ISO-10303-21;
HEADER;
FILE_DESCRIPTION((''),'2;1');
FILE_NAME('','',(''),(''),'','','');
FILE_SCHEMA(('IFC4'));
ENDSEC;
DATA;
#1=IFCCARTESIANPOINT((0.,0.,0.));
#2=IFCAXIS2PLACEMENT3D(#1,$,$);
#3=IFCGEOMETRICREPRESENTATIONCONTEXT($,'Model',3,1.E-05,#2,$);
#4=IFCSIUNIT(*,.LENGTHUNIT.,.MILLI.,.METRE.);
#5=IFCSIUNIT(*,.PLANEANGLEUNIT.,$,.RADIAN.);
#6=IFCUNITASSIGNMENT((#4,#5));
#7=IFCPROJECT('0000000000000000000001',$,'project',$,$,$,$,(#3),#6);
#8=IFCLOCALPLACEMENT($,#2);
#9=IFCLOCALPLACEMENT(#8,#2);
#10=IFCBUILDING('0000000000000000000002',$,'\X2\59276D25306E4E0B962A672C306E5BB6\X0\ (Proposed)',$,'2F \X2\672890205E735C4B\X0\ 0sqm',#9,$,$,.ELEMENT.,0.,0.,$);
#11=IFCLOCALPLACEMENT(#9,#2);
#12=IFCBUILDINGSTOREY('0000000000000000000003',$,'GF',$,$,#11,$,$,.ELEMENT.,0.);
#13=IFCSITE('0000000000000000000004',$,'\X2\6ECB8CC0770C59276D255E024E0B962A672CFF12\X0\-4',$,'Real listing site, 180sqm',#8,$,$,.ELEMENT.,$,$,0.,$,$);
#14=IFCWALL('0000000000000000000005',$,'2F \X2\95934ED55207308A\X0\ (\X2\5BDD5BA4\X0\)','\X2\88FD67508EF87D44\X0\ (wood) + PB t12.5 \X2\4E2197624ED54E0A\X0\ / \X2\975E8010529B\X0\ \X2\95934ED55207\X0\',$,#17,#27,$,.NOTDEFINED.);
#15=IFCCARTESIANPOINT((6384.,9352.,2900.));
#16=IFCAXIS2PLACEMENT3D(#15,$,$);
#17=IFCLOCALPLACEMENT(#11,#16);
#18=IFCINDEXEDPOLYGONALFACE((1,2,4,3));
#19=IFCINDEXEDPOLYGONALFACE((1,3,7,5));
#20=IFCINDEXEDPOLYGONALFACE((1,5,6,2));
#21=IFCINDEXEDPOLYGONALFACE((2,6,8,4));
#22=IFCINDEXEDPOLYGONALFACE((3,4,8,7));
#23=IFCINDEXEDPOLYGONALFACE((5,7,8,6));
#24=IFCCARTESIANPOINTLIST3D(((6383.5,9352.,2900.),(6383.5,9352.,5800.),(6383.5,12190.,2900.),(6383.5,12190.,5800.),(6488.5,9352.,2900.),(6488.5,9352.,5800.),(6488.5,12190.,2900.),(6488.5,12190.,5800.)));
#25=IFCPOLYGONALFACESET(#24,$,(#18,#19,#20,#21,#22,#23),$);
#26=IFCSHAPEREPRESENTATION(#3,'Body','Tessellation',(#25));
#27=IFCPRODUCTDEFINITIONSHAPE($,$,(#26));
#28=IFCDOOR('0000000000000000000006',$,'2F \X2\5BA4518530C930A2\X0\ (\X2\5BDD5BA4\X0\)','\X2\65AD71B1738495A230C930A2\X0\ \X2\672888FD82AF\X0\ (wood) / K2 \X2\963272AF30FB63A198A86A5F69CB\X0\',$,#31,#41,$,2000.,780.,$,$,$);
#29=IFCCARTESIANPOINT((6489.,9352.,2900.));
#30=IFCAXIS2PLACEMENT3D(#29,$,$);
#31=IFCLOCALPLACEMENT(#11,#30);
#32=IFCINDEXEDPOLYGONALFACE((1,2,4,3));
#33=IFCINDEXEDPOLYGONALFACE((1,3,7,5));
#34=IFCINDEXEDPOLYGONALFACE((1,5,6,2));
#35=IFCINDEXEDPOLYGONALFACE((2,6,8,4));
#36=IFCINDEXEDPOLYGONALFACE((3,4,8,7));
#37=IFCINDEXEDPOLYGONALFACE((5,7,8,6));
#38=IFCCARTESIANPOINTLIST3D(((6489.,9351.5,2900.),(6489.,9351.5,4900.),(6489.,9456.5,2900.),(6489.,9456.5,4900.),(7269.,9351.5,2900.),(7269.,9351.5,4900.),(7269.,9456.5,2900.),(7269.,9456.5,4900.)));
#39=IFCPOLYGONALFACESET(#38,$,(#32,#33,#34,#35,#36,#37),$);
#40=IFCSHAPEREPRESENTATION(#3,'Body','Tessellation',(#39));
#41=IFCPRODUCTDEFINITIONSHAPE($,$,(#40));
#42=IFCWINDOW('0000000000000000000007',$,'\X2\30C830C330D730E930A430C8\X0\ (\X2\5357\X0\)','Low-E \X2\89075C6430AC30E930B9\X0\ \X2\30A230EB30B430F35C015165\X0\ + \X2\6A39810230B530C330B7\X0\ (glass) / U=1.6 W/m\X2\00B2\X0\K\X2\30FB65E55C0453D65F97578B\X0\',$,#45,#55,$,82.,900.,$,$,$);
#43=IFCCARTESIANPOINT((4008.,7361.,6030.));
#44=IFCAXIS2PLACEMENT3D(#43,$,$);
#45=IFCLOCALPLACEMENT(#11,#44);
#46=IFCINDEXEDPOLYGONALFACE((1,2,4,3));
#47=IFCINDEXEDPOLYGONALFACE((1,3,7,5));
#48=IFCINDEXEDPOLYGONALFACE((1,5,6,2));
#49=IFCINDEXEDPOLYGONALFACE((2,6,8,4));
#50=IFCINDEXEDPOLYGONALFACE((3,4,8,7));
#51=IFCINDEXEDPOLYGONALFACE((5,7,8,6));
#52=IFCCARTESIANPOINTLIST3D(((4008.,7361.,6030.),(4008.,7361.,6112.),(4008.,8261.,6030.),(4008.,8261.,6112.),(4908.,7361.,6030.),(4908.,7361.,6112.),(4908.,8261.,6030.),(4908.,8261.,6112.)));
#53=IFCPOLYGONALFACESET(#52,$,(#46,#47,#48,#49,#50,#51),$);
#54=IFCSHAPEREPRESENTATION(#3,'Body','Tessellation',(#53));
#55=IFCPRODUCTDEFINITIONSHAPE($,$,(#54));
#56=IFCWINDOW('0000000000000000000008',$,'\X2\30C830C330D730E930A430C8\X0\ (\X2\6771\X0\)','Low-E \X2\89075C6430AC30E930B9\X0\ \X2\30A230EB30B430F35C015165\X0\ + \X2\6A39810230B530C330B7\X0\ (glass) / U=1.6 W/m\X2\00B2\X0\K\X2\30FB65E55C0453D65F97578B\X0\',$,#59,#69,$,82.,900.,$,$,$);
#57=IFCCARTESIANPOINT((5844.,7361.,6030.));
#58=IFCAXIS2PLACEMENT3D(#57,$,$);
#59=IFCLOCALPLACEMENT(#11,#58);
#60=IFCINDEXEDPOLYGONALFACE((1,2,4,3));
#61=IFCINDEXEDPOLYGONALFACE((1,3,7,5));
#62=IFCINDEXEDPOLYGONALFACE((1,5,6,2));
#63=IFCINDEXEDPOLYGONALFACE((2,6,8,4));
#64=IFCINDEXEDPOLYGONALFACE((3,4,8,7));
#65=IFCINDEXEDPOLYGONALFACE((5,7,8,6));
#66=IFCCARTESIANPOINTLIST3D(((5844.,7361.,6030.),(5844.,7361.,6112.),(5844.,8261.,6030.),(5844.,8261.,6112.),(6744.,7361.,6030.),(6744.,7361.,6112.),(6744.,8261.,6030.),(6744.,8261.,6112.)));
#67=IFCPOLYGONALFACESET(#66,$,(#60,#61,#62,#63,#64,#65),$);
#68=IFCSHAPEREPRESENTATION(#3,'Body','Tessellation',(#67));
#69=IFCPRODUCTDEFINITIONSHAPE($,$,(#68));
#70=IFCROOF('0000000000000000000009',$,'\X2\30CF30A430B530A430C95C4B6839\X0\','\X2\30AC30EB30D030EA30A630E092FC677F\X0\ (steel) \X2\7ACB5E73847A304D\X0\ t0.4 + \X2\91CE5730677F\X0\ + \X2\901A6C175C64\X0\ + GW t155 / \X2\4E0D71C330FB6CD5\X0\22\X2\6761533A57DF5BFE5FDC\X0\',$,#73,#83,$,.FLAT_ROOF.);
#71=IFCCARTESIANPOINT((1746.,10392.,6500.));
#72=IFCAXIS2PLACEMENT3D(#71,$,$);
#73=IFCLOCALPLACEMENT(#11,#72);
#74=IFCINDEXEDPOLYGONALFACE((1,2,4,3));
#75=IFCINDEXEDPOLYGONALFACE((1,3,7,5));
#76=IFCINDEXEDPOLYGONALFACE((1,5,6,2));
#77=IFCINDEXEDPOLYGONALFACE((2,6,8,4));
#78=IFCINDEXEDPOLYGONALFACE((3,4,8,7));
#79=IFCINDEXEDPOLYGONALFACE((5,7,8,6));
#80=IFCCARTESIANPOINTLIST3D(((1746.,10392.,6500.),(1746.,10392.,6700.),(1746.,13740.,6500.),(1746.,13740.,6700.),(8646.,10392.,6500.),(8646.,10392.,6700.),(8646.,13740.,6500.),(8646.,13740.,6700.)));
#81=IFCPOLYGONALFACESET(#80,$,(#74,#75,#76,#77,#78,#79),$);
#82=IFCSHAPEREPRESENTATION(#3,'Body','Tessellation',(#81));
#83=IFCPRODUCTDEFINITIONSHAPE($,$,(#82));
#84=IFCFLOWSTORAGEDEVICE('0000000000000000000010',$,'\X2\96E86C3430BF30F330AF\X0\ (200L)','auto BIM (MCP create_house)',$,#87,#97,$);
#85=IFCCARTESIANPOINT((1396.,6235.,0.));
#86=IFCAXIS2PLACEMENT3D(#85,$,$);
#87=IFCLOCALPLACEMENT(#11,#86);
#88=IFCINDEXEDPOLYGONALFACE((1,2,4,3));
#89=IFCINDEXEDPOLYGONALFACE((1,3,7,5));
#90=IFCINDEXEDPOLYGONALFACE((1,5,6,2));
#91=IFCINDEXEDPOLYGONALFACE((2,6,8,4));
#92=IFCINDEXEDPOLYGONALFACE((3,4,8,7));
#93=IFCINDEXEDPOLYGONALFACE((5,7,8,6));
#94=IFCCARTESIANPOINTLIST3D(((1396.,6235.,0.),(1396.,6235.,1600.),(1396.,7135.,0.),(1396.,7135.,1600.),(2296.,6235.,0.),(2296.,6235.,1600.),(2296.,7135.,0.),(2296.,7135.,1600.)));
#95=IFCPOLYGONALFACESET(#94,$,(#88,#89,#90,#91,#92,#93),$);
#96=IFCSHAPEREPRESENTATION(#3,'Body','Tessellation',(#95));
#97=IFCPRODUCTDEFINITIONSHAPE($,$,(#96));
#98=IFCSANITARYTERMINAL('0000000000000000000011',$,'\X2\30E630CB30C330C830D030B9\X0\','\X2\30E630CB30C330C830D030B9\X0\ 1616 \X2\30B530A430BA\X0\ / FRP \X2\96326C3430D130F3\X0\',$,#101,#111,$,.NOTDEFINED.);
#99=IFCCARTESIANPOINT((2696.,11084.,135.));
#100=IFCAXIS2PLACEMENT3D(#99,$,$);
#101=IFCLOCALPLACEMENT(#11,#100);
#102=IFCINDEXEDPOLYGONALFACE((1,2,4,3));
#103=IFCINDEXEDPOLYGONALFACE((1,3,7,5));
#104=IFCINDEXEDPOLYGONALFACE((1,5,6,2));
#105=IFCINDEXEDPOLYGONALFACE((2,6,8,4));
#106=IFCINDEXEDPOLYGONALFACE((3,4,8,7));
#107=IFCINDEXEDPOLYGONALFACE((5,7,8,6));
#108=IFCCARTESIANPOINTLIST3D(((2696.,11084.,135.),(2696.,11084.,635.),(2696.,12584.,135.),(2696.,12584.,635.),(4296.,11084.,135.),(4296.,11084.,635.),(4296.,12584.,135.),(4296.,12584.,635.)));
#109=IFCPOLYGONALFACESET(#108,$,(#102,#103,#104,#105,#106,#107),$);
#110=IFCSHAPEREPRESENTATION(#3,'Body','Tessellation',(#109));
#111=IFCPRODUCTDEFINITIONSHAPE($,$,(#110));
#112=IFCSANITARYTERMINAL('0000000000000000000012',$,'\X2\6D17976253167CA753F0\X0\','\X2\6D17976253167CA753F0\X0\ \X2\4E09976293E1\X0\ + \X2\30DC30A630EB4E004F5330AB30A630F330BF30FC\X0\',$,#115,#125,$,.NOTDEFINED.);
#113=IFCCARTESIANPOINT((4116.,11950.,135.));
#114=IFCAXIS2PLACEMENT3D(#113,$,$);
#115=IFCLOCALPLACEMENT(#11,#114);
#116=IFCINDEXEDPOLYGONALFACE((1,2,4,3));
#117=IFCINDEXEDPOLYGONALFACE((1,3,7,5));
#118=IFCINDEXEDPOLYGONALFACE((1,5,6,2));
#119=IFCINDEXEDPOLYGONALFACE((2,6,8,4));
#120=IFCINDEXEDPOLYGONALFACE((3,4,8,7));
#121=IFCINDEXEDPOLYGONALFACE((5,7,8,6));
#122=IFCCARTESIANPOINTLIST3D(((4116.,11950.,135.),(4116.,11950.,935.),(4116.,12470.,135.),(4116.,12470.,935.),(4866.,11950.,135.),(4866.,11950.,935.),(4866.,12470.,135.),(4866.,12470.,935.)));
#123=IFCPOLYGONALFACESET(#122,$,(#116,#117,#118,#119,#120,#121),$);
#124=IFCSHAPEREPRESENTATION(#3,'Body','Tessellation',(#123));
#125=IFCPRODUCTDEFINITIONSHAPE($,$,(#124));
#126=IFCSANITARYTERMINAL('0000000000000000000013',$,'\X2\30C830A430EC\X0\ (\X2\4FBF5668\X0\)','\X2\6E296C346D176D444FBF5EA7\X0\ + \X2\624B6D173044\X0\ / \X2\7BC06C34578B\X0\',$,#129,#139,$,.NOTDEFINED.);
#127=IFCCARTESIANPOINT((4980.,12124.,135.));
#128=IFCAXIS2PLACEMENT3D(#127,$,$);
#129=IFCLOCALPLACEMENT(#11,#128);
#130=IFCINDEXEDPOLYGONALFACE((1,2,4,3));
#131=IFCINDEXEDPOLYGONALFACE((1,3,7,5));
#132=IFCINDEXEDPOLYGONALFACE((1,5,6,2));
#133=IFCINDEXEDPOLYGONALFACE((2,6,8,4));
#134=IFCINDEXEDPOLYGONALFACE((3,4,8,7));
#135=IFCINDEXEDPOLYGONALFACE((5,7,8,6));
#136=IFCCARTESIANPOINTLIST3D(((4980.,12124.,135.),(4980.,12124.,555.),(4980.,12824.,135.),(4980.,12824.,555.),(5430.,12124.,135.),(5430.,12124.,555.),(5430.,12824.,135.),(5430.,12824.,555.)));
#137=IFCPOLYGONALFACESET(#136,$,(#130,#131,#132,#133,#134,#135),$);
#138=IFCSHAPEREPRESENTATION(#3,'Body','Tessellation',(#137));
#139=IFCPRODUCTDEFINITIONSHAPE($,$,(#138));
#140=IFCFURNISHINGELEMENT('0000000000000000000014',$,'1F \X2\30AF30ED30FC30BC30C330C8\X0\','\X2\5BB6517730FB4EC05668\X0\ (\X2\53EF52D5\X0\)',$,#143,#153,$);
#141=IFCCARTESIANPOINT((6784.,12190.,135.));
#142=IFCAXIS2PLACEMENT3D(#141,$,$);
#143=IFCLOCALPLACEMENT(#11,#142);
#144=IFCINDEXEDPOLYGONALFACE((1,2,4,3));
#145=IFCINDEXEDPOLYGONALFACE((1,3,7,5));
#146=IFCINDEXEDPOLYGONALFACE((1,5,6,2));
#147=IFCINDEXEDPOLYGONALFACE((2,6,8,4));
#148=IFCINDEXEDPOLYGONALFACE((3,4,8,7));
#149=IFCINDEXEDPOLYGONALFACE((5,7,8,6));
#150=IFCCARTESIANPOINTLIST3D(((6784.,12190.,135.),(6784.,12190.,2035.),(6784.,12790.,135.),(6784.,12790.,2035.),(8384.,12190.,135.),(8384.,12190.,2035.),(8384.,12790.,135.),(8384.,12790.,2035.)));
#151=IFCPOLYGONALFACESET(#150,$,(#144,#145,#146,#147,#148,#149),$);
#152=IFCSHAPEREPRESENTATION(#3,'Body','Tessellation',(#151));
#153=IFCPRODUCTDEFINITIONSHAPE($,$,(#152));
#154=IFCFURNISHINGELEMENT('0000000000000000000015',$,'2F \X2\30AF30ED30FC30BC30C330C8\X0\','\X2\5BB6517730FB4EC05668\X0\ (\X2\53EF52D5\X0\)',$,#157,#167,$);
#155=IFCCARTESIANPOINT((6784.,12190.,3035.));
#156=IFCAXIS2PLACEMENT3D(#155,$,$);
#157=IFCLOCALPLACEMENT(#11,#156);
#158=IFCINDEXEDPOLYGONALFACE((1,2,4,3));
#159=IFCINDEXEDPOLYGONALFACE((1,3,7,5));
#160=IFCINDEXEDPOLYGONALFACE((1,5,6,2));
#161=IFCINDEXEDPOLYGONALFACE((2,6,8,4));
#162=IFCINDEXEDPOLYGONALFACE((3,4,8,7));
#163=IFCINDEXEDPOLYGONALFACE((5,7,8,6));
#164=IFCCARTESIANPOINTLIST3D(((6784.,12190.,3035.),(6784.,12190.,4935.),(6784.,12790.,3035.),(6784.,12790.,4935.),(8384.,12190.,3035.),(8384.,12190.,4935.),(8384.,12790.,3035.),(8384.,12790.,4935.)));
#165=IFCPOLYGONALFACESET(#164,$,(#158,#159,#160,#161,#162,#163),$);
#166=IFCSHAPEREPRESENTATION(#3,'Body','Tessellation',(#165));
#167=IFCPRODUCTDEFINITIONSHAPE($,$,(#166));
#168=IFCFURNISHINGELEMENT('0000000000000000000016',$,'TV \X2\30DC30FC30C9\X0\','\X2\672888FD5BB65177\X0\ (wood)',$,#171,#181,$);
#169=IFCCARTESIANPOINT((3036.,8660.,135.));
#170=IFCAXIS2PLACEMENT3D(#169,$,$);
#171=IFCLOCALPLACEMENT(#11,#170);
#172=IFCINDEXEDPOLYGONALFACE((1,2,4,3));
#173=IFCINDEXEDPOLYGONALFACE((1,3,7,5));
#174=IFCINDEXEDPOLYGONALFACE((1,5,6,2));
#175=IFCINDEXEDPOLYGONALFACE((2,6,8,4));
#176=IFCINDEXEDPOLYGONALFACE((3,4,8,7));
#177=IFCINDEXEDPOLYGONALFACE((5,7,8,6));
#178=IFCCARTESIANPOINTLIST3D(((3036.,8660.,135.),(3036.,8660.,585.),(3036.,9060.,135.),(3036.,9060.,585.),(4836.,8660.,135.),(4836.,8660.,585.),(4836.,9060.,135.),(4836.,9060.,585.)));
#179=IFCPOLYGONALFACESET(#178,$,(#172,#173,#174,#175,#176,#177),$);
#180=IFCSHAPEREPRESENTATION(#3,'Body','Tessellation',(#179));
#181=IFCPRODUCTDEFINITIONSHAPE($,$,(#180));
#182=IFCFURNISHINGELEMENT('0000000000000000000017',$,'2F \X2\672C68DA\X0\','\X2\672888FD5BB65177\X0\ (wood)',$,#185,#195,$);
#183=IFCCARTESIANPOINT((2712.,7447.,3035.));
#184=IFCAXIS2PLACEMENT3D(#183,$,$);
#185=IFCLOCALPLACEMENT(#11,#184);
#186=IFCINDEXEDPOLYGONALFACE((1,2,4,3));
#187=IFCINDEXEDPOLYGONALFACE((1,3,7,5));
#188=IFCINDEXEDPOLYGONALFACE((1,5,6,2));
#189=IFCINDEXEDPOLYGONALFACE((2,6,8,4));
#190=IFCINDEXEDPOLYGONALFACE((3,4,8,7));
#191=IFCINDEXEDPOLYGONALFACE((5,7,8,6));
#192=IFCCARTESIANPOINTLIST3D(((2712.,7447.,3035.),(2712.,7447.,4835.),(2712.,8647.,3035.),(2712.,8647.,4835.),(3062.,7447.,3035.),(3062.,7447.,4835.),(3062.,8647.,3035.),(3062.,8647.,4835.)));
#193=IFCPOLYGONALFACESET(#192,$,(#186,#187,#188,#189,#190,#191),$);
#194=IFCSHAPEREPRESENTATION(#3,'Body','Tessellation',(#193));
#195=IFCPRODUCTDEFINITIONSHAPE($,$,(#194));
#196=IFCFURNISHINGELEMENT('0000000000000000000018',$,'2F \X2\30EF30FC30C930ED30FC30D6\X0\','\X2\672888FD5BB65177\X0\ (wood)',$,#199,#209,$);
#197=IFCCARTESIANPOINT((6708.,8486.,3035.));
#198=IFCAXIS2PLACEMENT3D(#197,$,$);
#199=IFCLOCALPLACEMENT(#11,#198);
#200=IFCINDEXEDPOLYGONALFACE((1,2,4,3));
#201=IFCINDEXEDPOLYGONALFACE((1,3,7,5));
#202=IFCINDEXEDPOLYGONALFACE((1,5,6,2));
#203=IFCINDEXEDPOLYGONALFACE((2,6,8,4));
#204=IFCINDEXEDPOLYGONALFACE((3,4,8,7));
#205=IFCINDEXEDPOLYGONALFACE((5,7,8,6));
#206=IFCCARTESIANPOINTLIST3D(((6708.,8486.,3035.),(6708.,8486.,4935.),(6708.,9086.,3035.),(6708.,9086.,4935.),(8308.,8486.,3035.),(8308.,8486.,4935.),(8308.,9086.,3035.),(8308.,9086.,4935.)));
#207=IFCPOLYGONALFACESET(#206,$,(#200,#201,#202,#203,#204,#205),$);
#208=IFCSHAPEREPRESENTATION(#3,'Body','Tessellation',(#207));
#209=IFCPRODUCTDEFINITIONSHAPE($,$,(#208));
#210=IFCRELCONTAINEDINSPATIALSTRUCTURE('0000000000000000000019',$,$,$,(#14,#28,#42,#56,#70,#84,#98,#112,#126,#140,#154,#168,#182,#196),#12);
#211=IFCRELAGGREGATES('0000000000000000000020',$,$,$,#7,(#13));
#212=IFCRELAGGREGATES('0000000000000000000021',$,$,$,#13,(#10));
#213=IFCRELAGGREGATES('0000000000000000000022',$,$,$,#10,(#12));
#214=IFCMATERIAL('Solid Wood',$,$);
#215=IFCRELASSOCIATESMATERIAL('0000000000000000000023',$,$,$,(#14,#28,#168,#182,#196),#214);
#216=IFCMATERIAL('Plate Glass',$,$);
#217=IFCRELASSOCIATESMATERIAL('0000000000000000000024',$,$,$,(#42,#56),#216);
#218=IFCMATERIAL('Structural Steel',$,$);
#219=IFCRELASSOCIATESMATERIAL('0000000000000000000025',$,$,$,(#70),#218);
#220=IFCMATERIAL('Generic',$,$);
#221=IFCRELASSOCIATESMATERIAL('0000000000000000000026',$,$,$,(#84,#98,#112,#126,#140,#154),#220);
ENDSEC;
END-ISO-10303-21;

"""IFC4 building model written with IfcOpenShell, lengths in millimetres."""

from ifc_helpers import new_model, si_unit, frame, frame_2d, origin, place, context, project, spatial, rectangle, extrude, material, element, save


model = new_model("IFC4")

# Units and contexts
model_context = context("Model", 3, precision=1e-05, world=origin())
ifc_project = project(units=[si_unit("LENGTHUNIT", "METRE", prefix="MILLI"), si_unit("PLANEANGLEUNIT", "RADIAN")], contexts=[model_context])

# Site, building, storey
site_placement = place(None, origin())
site = spatial("IfcSite", under=ifc_project, at=site_placement, Name="滋賀県大津市下阪本２-4", ObjectType="Real listing site, 180sqm", CompositionType="ELEMENT", RefElevation=0.0)
building_placement = place(site_placement, origin())
building = spatial("IfcBuilding", under=site, at=building_placement, Name="大津の下阪本の家 (Proposed)", ObjectType="2F 木造平屋 0sqm", CompositionType="ELEMENT", ElevationOfRefHeight=0.0, ElevationOfTerrain=0.0)
storey_placement = place(building_placement, origin())
storey = spatial("IfcBuildingStorey", under=building, at=storey_placement, Name="GF", CompositionType="ELEMENT", Elevation=0.0)

# Shared definitions
ifc_material_1 = material(Name="Solid Wood")
ifc_material_2 = material(Name="Plate Glass")

# Wall
wall_1_placement = place(storey_placement, frame((6384.0, 9352.0, 2900.0)))
element("IfcWall", 1, at=wall_1_placement, inside=storey, material=ifc_material_1, Name="2F 間仕切り (寝室)", Description="製材軸組 (wood) + PB t12.5 両面仕上 / 非耐力 間仕切", PredefinedType="NOTDEFINED", context=model_context, shape_type="SweptSolid", body=[
    extrude(rectangle(XDim=105.0, YDim=2838.0, at=frame_2d((52.0, 1419.0))), frame((6384.0, 9352.0, 2900.0)), (0.0, 0.0, 1.0), 2900.0),
])

# Door
door_1_placement = place(storey_placement, frame((6489.0, 9352.0, 2900.0)))
element("IfcDoor", 2, at=door_1_placement, inside=storey, material=ifc_material_1, Name="2F 室内ドア (寝室)", Description="断熱玄関ドア 木製芯 (wood) / K2 防犯・採風機構", OverallHeight=2000.0, OverallWidth=780.0, context=model_context, shape_type="SweptSolid", body=[
    extrude(rectangle(XDim=780.0, YDim=105.0, at=frame_2d((390.0, 52.0))), frame((6489.0, 9352.0, 2900.0)), (0.0, 0.0, 1.0), 2000.0),
])

# Windows
window_1_placement = place(storey_placement, frame((4008.0, 7361.0, 6030.0)))
element("IfcWindow", 3, at=window_1_placement, inside=storey, material=ifc_material_2, Name="トップライト (南)", Description="Low-E 複層ガラス アルゴン封入 + 樹脂サッシ (glass) / U=1.6 W/m²K・日射取得型", OverallHeight=82.0, OverallWidth=900.0, context=model_context, shape_type="SweptSolid", body=[
    extrude(rectangle(XDim=900.0, YDim=900.0, at=frame_2d((450.0, 450.0))), frame((4008.0, 7361.0, 6030.0)), (0.0, 0.0, 1.0), 82.0),
])
window_2_placement = place(storey_placement, frame((5844.0, 7361.0, 6030.0)))
element("IfcWindow", 4, at=window_2_placement, inside=storey, material=ifc_material_2, Name="トップライト (東)", Description="Low-E 複層ガラス アルゴン封入 + 樹脂サッシ (glass) / U=1.6 W/m²K・日射取得型", OverallHeight=82.0, OverallWidth=900.0, context=model_context, shape_type="SweptSolid", body=[
    extrude(rectangle(XDim=900.0, YDim=900.0, at=frame_2d((450.0, 450.0))), frame((5844.0, 7361.0, 6030.0)), (0.0, 0.0, 1.0), 82.0),
])

# Roof
ifc_material_3 = material(Name="Structural Steel")
roof_placement = place(storey_placement, frame((1746.0, 10392.0, 6500.0)))
element("IfcRoof", 5, at=roof_placement, inside=storey, material=ifc_material_3, Name="ハイサイド屋根", Description="ガルバリウム鋼板 (steel) 立平葺き t0.4 + 野地板 + 通気層 + GW t155 / 不燃・法22条区域対応", PredefinedType="FLAT_ROOF", context=model_context, shape_type="SweptSolid", body=[
    extrude(rectangle(XDim=6900.0, YDim=3348.0, at=frame_2d((3450.0, 1674.0))), frame((1746.0, 10392.0, 6500.0)), (0.0, 0.0, 1.0), 200.0),
])

# Flow storage device
ifc_material_4 = material(Name="Generic")
flow_storage_device_placement = place(storey_placement, frame((1396.0, 6235.0, 0.0)))
element("IfcFlowStorageDevice", 6, at=flow_storage_device_placement, inside=storey, material=ifc_material_4, Name="雨水タンク (200L)", Description="auto BIM (MCP create_house)", context=model_context, shape_type="SweptSolid", body=[
    extrude(rectangle(XDim=900.0, YDim=900.0, at=frame_2d((450.0, 450.0))), frame((1396.0, 6235.0, 0.0)), (0.0, 0.0, 1.0), 1600.0),
])

# Sanitary terminals
sanitary_terminal_1_placement = place(storey_placement, frame((2696.0, 11084.0, 135.0)))
element("IfcSanitaryTerminal", 7, at=sanitary_terminal_1_placement, inside=storey, material=ifc_material_4, Name="ユニットバス", Description="ユニットバス 1616 サイズ / FRP 防水パン", PredefinedType="NOTDEFINED", context=model_context, shape_type="SweptSolid", body=[
    extrude(rectangle(XDim=1600.0, YDim=1500.0, at=frame_2d((800.0, 750.0))), frame((2696.0, 11084.0, 135.0)), (0.0, 0.0, 1.0), 500.0),
])
sanitary_terminal_2_placement = place(storey_placement, frame((4116.0, 11950.0, 135.0)))
element("IfcSanitaryTerminal", 8, at=sanitary_terminal_2_placement, inside=storey, material=ifc_material_4, Name="洗面化粧台", Description="洗面化粧台 三面鏡 + ボウル一体カウンター", PredefinedType="NOTDEFINED", context=model_context, shape_type="SweptSolid", body=[
    extrude(rectangle(XDim=750.0, YDim=520.0, at=frame_2d((375.0, 260.0))), frame((4116.0, 11950.0, 135.0)), (0.0, 0.0, 1.0), 800.0),
])
sanitary_terminal_3_placement = place(storey_placement, frame((4980.0, 12124.0, 135.0)))
element("IfcSanitaryTerminal", 9, at=sanitary_terminal_3_placement, inside=storey, material=ifc_material_4, Name="トイレ (便器)", Description="温水洗浄便座 + 手洗い / 節水型", PredefinedType="NOTDEFINED", context=model_context, shape_type="SweptSolid", body=[
    extrude(rectangle(XDim=450.0, YDim=700.0, at=frame_2d((225.0, 350.0))), frame((4980.0, 12124.0, 135.0)), (0.0, 0.0, 1.0), 420.0),
])

# Furnishing elements
furnishing_1_placement = place(storey_placement, frame((6784.0, 12190.0, 135.0)))
element("IfcFurnishingElement", 10, at=furnishing_1_placement, inside=storey, material=ifc_material_4, Name="1F クローゼット", Description="家具・什器 (可動)", context=model_context, shape_type="SweptSolid", body=[
    extrude(rectangle(XDim=1600.0, YDim=600.0, at=frame_2d((800.0, 300.0))), frame((6784.0, 12190.0, 135.0)), (0.0, 0.0, 1.0), 1900.0),
])
furnishing_2_placement = place(storey_placement, frame((6784.0, 12190.0, 3035.0)))
element("IfcFurnishingElement", 11, at=furnishing_2_placement, inside=storey, material=ifc_material_4, Name="2F クローゼット", Description="家具・什器 (可動)", context=model_context, shape_type="SweptSolid", body=[
    extrude(rectangle(XDim=1600.0, YDim=600.0, at=frame_2d((800.0, 300.0))), frame((6784.0, 12190.0, 3035.0)), (0.0, 0.0, 1.0), 1900.0),
])
furnishing_3_placement = place(storey_placement, frame((3036.0, 8660.0, 135.0)))
element("IfcFurnishingElement", 12, at=furnishing_3_placement, inside=storey, material=ifc_material_1, Name="TV ボード", Description="木製家具 (wood)", context=model_context, shape_type="SweptSolid", body=[
    extrude(rectangle(XDim=1800.0, YDim=400.0, at=frame_2d((900.0, 200.0))), frame((3036.0, 8660.0, 135.0)), (0.0, 0.0, 1.0), 450.0),
])
furnishing_4_placement = place(storey_placement, frame((2712.0, 7447.0, 3035.0)))
element("IfcFurnishingElement", 13, at=furnishing_4_placement, inside=storey, material=ifc_material_1, Name="2F 本棚", Description="木製家具 (wood)", context=model_context, shape_type="SweptSolid", body=[
    extrude(rectangle(XDim=350.0, YDim=1200.0, at=frame_2d((175.0, 600.0))), frame((2712.0, 7447.0, 3035.0)), (0.0, 0.0, 1.0), 1800.0),
])
furnishing_5_placement = place(storey_placement, frame((6708.0, 8486.0, 3035.0)))
element("IfcFurnishingElement", 14, at=furnishing_5_placement, inside=storey, material=ifc_material_1, Name="2F ワードローブ", Description="木製家具 (wood)", context=model_context, shape_type="SweptSolid", body=[
    extrude(rectangle(XDim=1600.0, YDim=600.0, at=frame_2d((800.0, 300.0))), frame((6708.0, 8486.0, 3035.0)), (0.0, 0.0, 1.0), 1900.0),
])

save(model, "model.ifc")
